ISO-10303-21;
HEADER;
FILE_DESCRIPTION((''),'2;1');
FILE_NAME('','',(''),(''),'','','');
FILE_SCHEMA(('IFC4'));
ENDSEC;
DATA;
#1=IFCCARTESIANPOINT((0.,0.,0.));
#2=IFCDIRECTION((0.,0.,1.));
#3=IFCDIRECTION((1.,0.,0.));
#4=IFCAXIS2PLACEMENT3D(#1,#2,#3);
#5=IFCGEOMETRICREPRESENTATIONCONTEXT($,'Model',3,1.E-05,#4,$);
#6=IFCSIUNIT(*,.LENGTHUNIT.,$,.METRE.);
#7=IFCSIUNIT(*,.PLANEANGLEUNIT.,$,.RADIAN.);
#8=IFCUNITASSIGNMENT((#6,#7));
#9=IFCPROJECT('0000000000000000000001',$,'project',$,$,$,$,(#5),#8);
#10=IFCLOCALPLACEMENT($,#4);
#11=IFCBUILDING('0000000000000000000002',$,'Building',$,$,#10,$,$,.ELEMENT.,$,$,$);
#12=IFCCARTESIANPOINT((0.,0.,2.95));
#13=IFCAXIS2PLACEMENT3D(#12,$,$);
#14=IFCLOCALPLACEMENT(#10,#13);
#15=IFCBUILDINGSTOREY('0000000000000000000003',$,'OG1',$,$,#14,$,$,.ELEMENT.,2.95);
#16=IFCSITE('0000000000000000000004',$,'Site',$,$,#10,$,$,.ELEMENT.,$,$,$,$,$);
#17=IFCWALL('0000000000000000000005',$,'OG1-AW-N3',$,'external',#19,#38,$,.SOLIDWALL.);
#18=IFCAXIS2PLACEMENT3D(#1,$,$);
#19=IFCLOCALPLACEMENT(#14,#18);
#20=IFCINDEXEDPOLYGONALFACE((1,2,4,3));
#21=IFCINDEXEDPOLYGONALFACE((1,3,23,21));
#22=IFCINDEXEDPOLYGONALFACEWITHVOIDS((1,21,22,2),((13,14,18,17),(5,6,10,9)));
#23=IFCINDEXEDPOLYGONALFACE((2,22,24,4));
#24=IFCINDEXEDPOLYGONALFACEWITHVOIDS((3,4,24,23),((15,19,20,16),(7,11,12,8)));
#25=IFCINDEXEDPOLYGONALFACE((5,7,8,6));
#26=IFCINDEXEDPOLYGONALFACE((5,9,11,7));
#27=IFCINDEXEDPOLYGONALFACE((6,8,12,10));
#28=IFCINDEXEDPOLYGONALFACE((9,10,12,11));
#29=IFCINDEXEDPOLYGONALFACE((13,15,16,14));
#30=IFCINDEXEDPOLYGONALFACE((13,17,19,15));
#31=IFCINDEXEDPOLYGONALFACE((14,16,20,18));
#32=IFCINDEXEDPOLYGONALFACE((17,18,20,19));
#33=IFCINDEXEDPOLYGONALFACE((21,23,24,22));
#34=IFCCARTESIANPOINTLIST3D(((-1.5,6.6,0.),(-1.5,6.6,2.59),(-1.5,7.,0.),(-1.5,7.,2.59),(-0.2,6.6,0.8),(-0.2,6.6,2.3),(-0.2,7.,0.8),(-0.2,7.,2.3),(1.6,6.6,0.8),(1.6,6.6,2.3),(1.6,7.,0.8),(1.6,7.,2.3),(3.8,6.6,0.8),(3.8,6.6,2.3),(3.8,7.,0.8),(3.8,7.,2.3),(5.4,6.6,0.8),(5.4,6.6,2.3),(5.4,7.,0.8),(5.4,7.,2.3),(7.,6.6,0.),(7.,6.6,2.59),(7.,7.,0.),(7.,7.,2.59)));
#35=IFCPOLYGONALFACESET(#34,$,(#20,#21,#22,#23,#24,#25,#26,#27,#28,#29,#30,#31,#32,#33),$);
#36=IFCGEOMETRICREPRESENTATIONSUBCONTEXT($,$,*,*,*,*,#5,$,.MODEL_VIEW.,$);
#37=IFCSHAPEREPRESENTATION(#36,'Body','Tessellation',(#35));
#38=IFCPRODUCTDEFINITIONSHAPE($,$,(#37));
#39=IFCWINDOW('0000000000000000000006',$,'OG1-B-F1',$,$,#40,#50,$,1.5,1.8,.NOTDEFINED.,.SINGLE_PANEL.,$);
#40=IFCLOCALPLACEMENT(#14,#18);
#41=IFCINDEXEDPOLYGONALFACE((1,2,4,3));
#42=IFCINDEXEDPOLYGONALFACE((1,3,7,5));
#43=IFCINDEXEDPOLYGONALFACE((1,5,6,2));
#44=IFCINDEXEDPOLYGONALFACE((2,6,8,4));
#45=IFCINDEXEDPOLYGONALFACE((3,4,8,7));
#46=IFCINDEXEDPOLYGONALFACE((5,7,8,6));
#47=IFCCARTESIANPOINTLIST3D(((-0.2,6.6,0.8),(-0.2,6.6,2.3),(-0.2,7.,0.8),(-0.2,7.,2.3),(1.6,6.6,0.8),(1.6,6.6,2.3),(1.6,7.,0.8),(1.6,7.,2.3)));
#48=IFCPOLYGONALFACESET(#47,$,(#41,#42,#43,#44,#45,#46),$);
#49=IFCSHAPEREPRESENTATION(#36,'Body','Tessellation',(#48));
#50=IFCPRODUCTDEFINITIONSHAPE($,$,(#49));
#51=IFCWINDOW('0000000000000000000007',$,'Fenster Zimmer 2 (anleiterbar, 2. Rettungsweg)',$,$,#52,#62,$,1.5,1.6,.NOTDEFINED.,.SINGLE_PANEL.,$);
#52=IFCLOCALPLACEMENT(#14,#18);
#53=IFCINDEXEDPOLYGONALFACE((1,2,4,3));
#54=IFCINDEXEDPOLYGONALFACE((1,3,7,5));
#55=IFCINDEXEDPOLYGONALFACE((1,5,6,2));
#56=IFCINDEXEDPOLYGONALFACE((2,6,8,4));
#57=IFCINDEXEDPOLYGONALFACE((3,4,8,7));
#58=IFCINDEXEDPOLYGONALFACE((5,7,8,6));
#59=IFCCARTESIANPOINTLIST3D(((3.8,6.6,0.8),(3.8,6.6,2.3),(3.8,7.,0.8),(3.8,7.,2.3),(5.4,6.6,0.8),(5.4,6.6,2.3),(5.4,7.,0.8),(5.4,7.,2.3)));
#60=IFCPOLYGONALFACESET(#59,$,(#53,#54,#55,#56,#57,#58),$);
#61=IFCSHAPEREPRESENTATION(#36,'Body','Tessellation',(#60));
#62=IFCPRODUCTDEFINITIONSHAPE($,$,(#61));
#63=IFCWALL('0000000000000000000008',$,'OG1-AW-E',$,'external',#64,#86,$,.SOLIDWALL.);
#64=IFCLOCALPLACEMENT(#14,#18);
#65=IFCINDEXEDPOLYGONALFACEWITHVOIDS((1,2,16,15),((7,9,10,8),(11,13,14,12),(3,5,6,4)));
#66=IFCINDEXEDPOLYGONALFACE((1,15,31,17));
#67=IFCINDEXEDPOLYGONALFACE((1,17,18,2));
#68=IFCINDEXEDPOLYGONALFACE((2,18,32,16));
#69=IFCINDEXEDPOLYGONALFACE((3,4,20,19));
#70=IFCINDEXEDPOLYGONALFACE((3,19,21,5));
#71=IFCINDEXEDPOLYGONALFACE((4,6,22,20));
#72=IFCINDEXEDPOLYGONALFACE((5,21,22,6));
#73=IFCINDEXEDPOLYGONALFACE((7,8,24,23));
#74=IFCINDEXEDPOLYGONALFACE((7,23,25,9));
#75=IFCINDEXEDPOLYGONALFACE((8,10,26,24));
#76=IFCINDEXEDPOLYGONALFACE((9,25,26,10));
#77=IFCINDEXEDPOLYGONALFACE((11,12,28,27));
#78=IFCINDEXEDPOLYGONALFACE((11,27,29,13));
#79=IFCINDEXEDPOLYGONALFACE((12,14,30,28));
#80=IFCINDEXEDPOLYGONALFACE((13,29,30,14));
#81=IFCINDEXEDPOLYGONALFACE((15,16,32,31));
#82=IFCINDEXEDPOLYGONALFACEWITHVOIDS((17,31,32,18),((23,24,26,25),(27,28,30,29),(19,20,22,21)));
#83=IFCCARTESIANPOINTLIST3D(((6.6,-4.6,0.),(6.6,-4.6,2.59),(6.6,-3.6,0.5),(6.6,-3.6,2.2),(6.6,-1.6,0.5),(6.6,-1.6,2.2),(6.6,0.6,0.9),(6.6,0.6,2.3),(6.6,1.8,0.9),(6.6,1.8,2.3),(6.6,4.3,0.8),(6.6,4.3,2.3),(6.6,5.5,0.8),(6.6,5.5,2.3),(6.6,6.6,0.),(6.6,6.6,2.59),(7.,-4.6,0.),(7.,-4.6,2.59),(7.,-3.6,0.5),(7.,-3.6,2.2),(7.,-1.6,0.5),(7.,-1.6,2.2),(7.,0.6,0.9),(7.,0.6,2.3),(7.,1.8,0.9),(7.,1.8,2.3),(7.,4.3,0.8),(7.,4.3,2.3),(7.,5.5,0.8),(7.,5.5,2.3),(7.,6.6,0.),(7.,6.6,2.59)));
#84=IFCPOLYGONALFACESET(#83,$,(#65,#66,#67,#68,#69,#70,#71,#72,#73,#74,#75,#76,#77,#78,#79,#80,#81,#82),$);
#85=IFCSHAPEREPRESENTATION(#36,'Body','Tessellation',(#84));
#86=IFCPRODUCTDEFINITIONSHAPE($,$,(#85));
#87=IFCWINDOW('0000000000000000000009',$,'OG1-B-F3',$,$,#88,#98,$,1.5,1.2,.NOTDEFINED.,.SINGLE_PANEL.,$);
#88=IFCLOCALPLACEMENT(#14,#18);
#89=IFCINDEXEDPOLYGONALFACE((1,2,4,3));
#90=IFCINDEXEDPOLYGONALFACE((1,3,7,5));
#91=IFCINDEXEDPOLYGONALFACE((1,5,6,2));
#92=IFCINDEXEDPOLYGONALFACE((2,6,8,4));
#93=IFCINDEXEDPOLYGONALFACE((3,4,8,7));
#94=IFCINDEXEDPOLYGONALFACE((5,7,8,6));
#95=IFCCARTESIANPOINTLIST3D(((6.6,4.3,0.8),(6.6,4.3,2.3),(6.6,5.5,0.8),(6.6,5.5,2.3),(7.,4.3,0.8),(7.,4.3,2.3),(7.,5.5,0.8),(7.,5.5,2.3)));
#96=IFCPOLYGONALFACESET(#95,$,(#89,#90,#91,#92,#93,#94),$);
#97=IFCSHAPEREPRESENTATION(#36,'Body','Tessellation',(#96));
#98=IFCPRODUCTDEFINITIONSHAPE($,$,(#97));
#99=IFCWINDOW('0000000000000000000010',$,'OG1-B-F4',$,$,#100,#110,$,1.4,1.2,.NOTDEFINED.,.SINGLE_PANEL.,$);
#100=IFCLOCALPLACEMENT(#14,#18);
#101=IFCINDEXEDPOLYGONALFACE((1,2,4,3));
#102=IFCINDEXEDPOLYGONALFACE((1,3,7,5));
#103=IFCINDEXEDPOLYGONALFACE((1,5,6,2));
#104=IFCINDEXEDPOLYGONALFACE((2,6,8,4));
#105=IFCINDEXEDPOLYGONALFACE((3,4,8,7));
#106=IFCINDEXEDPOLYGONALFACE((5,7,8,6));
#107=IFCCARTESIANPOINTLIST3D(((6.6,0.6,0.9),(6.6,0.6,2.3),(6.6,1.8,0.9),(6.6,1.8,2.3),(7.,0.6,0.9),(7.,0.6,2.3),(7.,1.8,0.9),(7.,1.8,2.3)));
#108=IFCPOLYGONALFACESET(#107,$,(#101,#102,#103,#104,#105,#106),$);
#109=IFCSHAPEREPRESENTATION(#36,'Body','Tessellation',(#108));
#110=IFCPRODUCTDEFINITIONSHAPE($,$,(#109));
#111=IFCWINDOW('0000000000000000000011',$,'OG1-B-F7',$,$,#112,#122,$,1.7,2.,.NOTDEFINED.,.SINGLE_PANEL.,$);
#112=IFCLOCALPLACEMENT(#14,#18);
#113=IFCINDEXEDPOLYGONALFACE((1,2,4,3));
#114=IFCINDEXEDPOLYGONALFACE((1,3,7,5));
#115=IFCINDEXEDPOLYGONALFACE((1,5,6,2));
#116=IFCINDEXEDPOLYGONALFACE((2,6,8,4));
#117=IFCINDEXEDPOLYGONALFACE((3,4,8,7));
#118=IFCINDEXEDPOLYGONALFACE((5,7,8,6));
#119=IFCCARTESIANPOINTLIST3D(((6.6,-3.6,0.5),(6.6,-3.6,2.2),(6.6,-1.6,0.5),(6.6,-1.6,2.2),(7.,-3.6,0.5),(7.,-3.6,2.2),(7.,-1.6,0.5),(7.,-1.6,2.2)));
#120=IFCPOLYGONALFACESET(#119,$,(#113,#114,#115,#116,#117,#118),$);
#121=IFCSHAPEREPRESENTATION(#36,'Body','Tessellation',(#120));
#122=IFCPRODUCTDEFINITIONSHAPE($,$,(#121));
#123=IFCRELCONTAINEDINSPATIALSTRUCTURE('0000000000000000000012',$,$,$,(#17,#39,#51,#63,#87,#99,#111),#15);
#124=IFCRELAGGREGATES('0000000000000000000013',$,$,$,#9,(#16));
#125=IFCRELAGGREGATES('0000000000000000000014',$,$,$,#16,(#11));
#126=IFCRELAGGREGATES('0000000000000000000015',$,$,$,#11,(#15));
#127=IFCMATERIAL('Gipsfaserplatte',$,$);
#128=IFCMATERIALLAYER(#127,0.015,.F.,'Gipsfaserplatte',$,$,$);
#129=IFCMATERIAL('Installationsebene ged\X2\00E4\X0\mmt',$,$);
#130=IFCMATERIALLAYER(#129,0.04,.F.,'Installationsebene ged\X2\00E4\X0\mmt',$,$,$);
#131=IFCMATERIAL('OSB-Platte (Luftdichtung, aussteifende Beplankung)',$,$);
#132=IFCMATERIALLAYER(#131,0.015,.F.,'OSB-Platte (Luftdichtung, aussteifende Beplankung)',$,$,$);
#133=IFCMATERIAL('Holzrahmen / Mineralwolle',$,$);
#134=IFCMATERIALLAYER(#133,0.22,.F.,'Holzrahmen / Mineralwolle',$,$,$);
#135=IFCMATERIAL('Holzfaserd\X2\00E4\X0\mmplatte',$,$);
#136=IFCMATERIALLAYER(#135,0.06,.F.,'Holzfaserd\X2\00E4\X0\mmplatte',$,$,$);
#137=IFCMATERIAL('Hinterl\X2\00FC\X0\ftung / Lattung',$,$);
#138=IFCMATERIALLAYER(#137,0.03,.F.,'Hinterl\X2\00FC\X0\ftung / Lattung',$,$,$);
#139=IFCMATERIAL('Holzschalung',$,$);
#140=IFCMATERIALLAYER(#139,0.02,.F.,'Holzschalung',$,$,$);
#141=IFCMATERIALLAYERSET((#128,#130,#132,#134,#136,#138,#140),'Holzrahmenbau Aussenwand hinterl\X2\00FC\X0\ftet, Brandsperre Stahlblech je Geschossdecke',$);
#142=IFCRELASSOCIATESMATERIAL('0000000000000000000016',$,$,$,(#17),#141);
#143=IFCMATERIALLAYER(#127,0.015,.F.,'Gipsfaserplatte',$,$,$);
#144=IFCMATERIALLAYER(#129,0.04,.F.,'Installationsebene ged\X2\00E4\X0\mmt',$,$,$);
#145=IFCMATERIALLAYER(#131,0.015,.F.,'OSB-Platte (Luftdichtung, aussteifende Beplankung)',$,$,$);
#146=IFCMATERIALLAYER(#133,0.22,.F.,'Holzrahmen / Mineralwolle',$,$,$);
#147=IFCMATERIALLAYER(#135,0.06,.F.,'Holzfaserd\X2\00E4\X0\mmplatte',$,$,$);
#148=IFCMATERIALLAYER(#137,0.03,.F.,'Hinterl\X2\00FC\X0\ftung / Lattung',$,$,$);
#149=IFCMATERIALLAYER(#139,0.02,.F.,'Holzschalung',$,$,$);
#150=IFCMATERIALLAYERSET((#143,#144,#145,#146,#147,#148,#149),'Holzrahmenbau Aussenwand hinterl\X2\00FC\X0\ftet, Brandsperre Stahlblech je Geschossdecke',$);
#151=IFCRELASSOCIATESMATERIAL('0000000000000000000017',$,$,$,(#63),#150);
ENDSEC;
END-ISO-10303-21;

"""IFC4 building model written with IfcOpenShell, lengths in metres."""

from ifc_helpers import new_model, si_unit, frame, frame_2d, origin, origin_with_axes, place, context, subcontext, project, spatial, rectangle, extrude, material, layer, layer_set, element, fill, save


model = new_model("IFC4")

# Units and contexts
model_context = context("Model", 3, precision=1e-05, world=origin_with_axes())
sub_context = subcontext(model_context, None, None, "MODEL_VIEW")
ifc_project = project(units=[si_unit("LENGTHUNIT", "METRE"), si_unit("PLANEANGLEUNIT", "RADIAN")], contexts=[model_context])

# Site, building, storey
placement = place(None, origin_with_axes())
site = spatial("IfcSite", under=ifc_project, at=placement, Name="Site", CompositionType="ELEMENT")
building = spatial("IfcBuilding", under=site, at=placement, Name="Building", CompositionType="ELEMENT")
storey_placement = place(placement, frame((0.0, 0.0, 2.95)))
storey = spatial("IfcBuildingStorey", under=building, at=storey_placement, Name="OG1", CompositionType="ELEMENT", Elevation=2.95)

# Walls, openings, windows
ifc_material_1 = material(Name="Gipsfaserplatte")
ifc_layer_1 = layer(ifc_material_1, 0.015, ventilated=False, Name="Gipsfaserplatte")
ifc_material_2 = material(Name="Installationsebene gedämmt")
ifc_layer_2 = layer(ifc_material_2, 0.04, ventilated=False, Name="Installationsebene gedämmt")
ifc_material_3 = material(Name="OSB-Platte (Luftdichtung, aussteifende Beplankung)")
ifc_layer_3 = layer(ifc_material_3, 0.015, ventilated=False, Name="OSB-Platte (Luftdichtung, aussteifende Beplankung)")
ifc_material_4 = material(Name="Holzrahmen / Mineralwolle")
ifc_layer_4 = layer(ifc_material_4, 0.22, ventilated=False, Name="Holzrahmen / Mineralwolle")
ifc_material_5 = material(Name="Holzfaserdämmplatte")
ifc_layer_5 = layer(ifc_material_5, 0.06, ventilated=False, Name="Holzfaserdämmplatte")
ifc_material_6 = material(Name="Hinterlüftung / Lattung")
ifc_layer_6 = layer(ifc_material_6, 0.03, ventilated=False, Name="Hinterlüftung / Lattung")
ifc_material_7 = material(Name="Holzschalung")
ifc_layer_7 = layer(ifc_material_7, 0.02, ventilated=False, Name="Holzschalung")
ifc_layer_set_1 = layer_set([ifc_layer_1, ifc_layer_2, ifc_layer_3, ifc_layer_4, ifc_layer_5, ifc_layer_6, ifc_layer_7], Name="Holzrahmenbau Aussenwand hinterlüftet, Brandsperre Stahlblech je Geschossdecke")
wall_1_placement = place(storey_placement, frame((-1.5, 6.8, 0.0), z_axis=(0.0, 0.0, 1.0), x_axis=(1.0, 0.0, 0.0)))
wall_1 = element("IfcWall", 1, at=wall_1_placement, inside=storey, material=ifc_layer_set_1, Name="OG1-AW-N3", ObjectType="external", PredefinedType="SOLIDWALL", context=sub_context, shape_type="SweptSolid", body=[
    extrude(rectangle(XDim=8.5, YDim=0.4, at=frame_2d((4.25, 0.0))), origin(), (0.0, 0.0, 1.0), 2.59),
])
opening_1_placement = place(wall_1_placement, frame((2.2, 0.25, 0.8), z_axis=(0.0, -1.0, 0.0), x_axis=(1.0, 0.0, 0.0)))
opening_1 = element("IfcOpeningElement", 2, at=opening_1_placement, cuts=wall_1, PredefinedType="OPENING", context=sub_context, shape_type="SweptSolid", body=[
    extrude(rectangle(XDim=1.8, YDim=1.5, at=frame_2d((0.0, 0.75))), origin(), (0.0, 0.0, 1.0), 0.5),
])
opening_2_placement = place(wall_1_placement, frame((6.1, 0.25, 0.8), z_axis=(0.0, -1.0, 0.0), x_axis=(1.0, 0.0, 0.0)))
opening_2 = element("IfcOpeningElement", 3, at=opening_2_placement, cuts=wall_1, PredefinedType="OPENING", context=sub_context, shape_type="SweptSolid", body=[
    extrude(rectangle(XDim=1.6, YDim=1.5, at=frame_2d((0.0, 0.75))), origin(), (0.0, 0.0, 1.0), 0.5),
])
window_1_placement = place(wall_1_placement, frame((2.2, 0.2, 0.8), z_axis=(0.0, -1.0, 0.0), x_axis=(1.0, 0.0, 0.0)))
window_1 = element("IfcWindow", 4, at=window_1_placement, inside=storey, Name="OG1-B-F1", OverallHeight=1.5, OverallWidth=1.8, PartitioningType="SINGLE_PANEL", PredefinedType="NOTDEFINED", context=sub_context, shape_type="SweptSolid", body=[
    extrude(rectangle(XDim=1.8, YDim=1.5, at=frame_2d((0.0, 0.75))), origin(), (0.0, 0.0, 1.0), 0.4),
])
fill(opening_1, window_1)
window_2_placement = place(wall_1_placement, frame((6.1, 0.2, 0.8), z_axis=(0.0, -1.0, 0.0), x_axis=(1.0, 0.0, 0.0)))
window_2 = element("IfcWindow", 5, at=window_2_placement, inside=storey, Name="Fenster Zimmer 2 (anleiterbar, 2. Rettungsweg)", OverallHeight=1.5, OverallWidth=1.6, PartitioningType="SINGLE_PANEL", PredefinedType="NOTDEFINED", context=sub_context, shape_type="SweptSolid", body=[
    extrude(rectangle(XDim=1.6, YDim=1.5, at=frame_2d((0.0, 0.75))), origin(), (0.0, 0.0, 1.0), 0.4),
])
fill(opening_2, window_2)
ifc_layer_8 = layer(ifc_material_1, 0.015, ventilated=False, Name="Gipsfaserplatte")
ifc_layer_9 = layer(ifc_material_2, 0.04, ventilated=False, Name="Installationsebene gedämmt")
ifc_layer_10 = layer(ifc_material_3, 0.015, ventilated=False, Name="OSB-Platte (Luftdichtung, aussteifende Beplankung)")
ifc_layer_11 = layer(ifc_material_4, 0.22, ventilated=False, Name="Holzrahmen / Mineralwolle")
ifc_layer_12 = layer(ifc_material_5, 0.06, ventilated=False, Name="Holzfaserdämmplatte")
ifc_layer_13 = layer(ifc_material_6, 0.03, ventilated=False, Name="Hinterlüftung / Lattung")
ifc_layer_14 = layer(ifc_material_7, 0.02, ventilated=False, Name="Holzschalung")
ifc_layer_set_2 = layer_set([ifc_layer_8, ifc_layer_9, ifc_layer_10, ifc_layer_11, ifc_layer_12, ifc_layer_13, ifc_layer_14], Name="Holzrahmenbau Aussenwand hinterlüftet, Brandsperre Stahlblech je Geschossdecke")
wall_2_placement = place(storey_placement, frame((6.8, 6.6, 0.0), z_axis=(0.0, 0.0, 1.0), x_axis=(0.0, -1.0, 0.0)))
wall_2 = element("IfcWall", 6, at=wall_2_placement, inside=storey, material=ifc_layer_set_2, Name="OG1-AW-E", ObjectType="external", PredefinedType="SOLIDWALL", context=sub_context, shape_type="SweptSolid", body=[
    extrude(rectangle(XDim=11.2, YDim=0.4, at=frame_2d((5.6, 0.0))), origin(), (0.0, 0.0, 1.0), 2.59),
])
opening_3_placement = place(wall_2_placement, frame((1.7, 0.25, 0.8), z_axis=(0.0, -1.0, 0.0), x_axis=(1.0, 0.0, 0.0)))
opening_3 = element("IfcOpeningElement", 7, at=opening_3_placement, cuts=wall_2, PredefinedType="OPENING", context=sub_context, shape_type="SweptSolid", body=[
    extrude(rectangle(XDim=1.2, YDim=1.5, at=frame_2d((0.0, 0.75))), origin(), (0.0, 0.0, 1.0), 0.5),
])
opening_4_placement = place(wall_2_placement, frame((5.4, 0.25, 0.9), z_axis=(0.0, -1.0, 0.0), x_axis=(1.0, 0.0, 0.0)))
opening_4 = element("IfcOpeningElement", 8, at=opening_4_placement, cuts=wall_2, PredefinedType="OPENING", context=sub_context, shape_type="SweptSolid", body=[
    extrude(rectangle(XDim=1.2, YDim=1.4, at=frame_2d((0.0, 0.7))), origin(), (0.0, 0.0, 1.0), 0.5),
])
opening_5_placement = place(wall_2_placement, frame((9.2, 0.25, 0.5), z_axis=(0.0, -1.0, 0.0), x_axis=(1.0, 0.0, 0.0)))
opening_5 = element("IfcOpeningElement", 9, at=opening_5_placement, cuts=wall_2, PredefinedType="OPENING", context=sub_context, shape_type="SweptSolid", body=[
    extrude(rectangle(XDim=2.0, YDim=1.7, at=frame_2d((0.0, 0.85))), origin(), (0.0, 0.0, 1.0), 0.5),
])
window_3_placement = place(wall_2_placement, frame((1.7, 0.2, 0.8), z_axis=(0.0, -1.0, 0.0), x_axis=(1.0, 0.0, 0.0)))
window_3 = element("IfcWindow", 10, at=window_3_placement, inside=storey, Name="OG1-B-F3", OverallHeight=1.5, OverallWidth=1.2, PartitioningType="SINGLE_PANEL", PredefinedType="NOTDEFINED", context=sub_context, shape_type="SweptSolid", body=[
    extrude(rectangle(XDim=1.2, YDim=1.5, at=frame_2d((0.0, 0.75))), origin(), (0.0, 0.0, 1.0), 0.4),
])
fill(opening_3, window_3)
window_4_placement = place(wall_2_placement, frame((5.4, 0.2, 0.9), z_axis=(0.0, -1.0, 0.0), x_axis=(1.0, 0.0, 0.0)))
window_4 = element("IfcWindow", 11, at=window_4_placement, inside=storey, Name="OG1-B-F4", OverallHeight=1.4, OverallWidth=1.2, PartitioningType="SINGLE_PANEL", PredefinedType="NOTDEFINED", context=sub_context, shape_type="SweptSolid", body=[
    extrude(rectangle(XDim=1.2, YDim=1.4, at=frame_2d((0.0, 0.7))), origin(), (0.0, 0.0, 1.0), 0.4),
])
fill(opening_4, window_4)
window_5_placement = place(wall_2_placement, frame((9.2, 0.2, 0.5), z_axis=(0.0, -1.0, 0.0), x_axis=(1.0, 0.0, 0.0)))
window_5 = element("IfcWindow", 12, at=window_5_placement, inside=storey, Name="OG1-B-F7", OverallHeight=1.7, OverallWidth=2.0, PartitioningType="SINGLE_PANEL", PredefinedType="NOTDEFINED", context=sub_context, shape_type="SweptSolid", body=[
    extrude(rectangle(XDim=2.0, YDim=1.7, at=frame_2d((0.0, 0.85))), origin(), (0.0, 0.0, 1.0), 0.4),
])
fill(opening_5, window_5)

save(model, "model.ifc")
